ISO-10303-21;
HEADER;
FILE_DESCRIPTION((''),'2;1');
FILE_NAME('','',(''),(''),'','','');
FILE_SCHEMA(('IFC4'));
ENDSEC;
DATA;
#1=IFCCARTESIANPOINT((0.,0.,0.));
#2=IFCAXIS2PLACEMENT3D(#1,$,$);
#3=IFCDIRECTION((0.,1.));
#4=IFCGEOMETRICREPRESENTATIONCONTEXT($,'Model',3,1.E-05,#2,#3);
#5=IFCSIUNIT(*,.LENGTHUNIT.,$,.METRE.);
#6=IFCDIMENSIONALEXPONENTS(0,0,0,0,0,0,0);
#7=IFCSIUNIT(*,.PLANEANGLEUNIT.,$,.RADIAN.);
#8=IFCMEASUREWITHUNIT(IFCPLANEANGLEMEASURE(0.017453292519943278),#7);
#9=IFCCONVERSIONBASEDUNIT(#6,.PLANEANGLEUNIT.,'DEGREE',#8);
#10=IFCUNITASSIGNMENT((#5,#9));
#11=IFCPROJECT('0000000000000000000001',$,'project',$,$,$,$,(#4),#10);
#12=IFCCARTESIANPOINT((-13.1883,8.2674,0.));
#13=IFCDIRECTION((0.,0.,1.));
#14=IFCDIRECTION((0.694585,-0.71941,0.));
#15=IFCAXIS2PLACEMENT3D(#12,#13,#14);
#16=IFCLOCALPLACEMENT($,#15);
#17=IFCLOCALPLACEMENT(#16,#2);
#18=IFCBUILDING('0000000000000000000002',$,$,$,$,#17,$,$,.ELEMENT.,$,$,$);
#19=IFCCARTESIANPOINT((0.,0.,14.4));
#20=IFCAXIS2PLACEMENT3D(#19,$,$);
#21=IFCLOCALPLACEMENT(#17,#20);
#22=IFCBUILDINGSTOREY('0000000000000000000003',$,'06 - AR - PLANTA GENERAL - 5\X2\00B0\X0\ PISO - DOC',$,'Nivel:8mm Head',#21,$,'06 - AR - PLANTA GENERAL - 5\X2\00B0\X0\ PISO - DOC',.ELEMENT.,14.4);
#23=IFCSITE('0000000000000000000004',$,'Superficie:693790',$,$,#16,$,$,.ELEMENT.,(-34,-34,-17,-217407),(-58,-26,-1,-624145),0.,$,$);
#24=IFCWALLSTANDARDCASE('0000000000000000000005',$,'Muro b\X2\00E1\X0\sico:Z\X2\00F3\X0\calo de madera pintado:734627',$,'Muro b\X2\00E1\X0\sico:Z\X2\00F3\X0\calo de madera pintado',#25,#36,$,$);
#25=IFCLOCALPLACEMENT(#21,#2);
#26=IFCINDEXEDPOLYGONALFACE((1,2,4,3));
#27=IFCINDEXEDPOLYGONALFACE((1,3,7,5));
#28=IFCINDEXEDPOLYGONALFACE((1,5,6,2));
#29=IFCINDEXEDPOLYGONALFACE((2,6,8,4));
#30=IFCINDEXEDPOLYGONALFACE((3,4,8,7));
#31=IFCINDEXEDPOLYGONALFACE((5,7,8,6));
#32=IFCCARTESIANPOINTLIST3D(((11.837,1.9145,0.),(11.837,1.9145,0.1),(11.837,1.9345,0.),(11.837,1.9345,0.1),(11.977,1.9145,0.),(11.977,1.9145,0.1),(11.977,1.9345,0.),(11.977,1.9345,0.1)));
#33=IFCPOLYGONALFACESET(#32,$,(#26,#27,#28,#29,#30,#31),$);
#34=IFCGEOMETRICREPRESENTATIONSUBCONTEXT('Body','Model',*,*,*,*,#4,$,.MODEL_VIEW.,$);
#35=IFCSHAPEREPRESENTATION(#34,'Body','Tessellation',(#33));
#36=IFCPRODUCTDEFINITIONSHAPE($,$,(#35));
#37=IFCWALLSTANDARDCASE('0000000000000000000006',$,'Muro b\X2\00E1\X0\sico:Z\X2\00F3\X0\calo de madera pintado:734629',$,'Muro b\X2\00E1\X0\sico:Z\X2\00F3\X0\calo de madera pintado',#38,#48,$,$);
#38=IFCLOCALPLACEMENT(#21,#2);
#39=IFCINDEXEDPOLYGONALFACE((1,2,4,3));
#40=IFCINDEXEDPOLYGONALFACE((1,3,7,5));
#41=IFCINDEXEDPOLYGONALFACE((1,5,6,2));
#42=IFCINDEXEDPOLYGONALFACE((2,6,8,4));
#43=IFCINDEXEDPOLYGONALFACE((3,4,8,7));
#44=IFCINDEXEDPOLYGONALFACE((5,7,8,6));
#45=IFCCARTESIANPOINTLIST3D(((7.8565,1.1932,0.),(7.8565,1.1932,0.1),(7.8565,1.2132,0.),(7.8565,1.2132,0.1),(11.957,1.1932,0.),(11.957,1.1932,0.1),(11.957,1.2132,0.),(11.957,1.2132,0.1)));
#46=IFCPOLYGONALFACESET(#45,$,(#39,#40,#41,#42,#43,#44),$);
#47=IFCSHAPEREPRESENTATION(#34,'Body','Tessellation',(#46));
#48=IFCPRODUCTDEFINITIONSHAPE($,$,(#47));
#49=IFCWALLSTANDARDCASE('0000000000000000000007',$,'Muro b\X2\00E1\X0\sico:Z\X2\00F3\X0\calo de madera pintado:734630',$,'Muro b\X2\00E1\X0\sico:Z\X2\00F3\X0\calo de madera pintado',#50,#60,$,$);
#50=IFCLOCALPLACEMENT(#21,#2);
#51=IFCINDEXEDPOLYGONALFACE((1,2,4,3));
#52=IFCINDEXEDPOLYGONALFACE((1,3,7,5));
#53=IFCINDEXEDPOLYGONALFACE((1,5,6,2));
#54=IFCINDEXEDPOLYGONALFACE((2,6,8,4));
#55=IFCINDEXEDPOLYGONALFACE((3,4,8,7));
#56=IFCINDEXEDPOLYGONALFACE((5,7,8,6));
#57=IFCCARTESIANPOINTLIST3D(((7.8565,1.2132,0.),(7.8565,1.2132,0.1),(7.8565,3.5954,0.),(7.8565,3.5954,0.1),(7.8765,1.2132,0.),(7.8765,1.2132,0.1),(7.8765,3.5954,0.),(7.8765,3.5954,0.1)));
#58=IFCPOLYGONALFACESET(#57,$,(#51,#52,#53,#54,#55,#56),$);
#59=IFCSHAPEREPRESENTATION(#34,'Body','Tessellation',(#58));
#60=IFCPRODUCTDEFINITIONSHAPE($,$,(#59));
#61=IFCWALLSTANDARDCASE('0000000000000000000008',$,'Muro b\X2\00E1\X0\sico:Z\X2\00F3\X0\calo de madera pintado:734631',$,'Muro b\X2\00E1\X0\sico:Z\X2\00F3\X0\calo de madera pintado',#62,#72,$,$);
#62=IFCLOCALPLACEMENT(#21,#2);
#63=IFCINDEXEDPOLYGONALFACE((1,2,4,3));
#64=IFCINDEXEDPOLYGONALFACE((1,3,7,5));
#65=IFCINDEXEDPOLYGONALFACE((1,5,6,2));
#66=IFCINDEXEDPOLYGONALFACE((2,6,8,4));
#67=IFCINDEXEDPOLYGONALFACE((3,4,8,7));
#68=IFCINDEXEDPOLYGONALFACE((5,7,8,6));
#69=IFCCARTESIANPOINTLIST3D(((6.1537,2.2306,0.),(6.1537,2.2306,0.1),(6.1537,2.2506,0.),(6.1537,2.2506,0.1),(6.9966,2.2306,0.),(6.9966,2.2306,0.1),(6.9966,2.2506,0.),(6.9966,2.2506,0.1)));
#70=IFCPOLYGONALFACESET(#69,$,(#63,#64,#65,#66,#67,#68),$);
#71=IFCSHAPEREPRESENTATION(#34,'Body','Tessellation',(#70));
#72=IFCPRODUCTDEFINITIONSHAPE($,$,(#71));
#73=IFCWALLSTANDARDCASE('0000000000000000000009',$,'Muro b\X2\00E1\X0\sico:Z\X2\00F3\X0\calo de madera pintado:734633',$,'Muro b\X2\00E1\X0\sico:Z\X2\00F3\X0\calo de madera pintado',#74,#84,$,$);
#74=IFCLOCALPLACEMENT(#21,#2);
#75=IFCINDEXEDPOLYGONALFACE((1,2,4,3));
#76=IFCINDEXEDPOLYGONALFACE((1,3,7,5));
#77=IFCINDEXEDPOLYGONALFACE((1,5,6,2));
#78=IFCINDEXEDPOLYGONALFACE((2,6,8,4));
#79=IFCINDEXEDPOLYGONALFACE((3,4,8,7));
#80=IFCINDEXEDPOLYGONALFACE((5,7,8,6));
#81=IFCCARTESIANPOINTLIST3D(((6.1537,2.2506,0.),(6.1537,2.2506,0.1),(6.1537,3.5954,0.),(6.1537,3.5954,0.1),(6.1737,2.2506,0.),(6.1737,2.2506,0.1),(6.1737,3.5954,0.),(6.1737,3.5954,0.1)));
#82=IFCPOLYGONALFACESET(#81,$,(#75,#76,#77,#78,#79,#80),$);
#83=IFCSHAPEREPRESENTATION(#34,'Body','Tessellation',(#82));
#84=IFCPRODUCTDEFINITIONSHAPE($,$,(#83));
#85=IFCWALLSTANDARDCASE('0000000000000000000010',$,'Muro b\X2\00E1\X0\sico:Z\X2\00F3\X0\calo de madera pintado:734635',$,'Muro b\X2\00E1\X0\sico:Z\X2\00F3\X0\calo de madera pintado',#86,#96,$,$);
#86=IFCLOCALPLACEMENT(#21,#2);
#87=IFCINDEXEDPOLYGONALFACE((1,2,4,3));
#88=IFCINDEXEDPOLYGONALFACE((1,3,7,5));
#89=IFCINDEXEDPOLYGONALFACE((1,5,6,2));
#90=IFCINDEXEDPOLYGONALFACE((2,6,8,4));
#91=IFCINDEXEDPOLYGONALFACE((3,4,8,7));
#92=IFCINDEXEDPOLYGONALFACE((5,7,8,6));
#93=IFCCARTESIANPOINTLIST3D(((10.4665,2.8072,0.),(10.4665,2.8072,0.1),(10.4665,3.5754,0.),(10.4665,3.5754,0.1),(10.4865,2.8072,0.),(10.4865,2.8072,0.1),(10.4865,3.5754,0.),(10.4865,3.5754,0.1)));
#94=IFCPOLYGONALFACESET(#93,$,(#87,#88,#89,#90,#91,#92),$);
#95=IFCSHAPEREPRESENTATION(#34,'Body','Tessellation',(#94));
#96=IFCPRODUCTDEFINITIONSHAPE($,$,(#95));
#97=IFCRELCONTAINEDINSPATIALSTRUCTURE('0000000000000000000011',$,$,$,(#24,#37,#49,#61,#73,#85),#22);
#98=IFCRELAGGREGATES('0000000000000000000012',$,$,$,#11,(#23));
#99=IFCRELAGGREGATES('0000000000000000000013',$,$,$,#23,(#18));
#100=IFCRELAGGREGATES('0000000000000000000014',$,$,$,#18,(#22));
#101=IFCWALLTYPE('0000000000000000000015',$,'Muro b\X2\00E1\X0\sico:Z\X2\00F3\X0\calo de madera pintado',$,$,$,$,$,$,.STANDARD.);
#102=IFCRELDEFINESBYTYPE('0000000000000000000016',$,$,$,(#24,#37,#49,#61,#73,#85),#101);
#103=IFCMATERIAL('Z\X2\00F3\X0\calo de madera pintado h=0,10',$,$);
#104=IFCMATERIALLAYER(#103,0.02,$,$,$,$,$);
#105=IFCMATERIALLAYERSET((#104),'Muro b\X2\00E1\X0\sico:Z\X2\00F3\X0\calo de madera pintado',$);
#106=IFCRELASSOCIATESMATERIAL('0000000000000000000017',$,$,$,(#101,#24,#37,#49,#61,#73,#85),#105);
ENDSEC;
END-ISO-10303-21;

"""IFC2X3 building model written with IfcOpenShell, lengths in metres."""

from ifc_helpers import new_model, entity, si_unit, converted_unit, direction, frame, frame_2d, origin, place, context, subcontext, project, spatial, rectangle, extrude, material, layer, layer_set, layer_usage, type_object, element, save


model = new_model("IFC2X3")

# Units and contexts
model_context = context("Model", 3, precision=1e-05, world=origin(), true_north=direction((0.0, 1.0)))
body_context = subcontext(model_context, "Body", "Model", "MODEL_VIEW")
ifc_project = project(units=[si_unit("LENGTHUNIT", "METRE"), converted_unit("PLANEANGLEUNIT", "DEGREE", entity("IfcPlaneAngleMeasure", 0.017453292519943278), si_unit("PLANEANGLEUNIT", "RADIAN"), dimensions=[0, 0, 0, 0, 0, 0, 0])], contexts=[model_context])

# Site, building, storey
site_placement = place(None, frame((-13.1883, 8.2674, 0.0), z_axis=(0.0, 0.0, 1.0), x_axis=(0.694585, -0.71941, 0.0)))
site = spatial("IfcSite", under=ifc_project, at=site_placement, Name="Superficie:693790", CompositionType="ELEMENT", RefLatitude=(-34, -34, -17, -217407), RefLongitude=(-58, -26, -1, -624145), RefElevation=0.0)
building_placement = place(site_placement, origin())
building = spatial("IfcBuilding", under=site, at=building_placement, CompositionType="ELEMENT")
storey_placement = place(building_placement, frame((0.0, 0.0, 14.4)))
storey = spatial("IfcBuildingStorey", under=building, at=storey_placement, Name="06 - AR - PLANTA GENERAL - 5° PISO - DOC", ObjectType="Nivel:8mm Head", LongName="06 - AR - PLANTA GENERAL - 5° PISO - DOC", CompositionType="ELEMENT", Elevation=14.4)

# Walls
ifc_material_1 = material(Name="Zócalo de madera pintado h=0,10")
ifc_layer_1 = layer(ifc_material_1, 0.02)
ifc_layer_set_1 = layer_set([ifc_layer_1], Name="Muro básico:Zócalo de madera pintado")
wall_type_1 = type_object("IfcWallType", Name="Muro básico:Zócalo de madera pintado", PredefinedType="STANDARD", material=ifc_layer_set_1)
ifc_layer_usage_1 = layer_usage(ifc_layer_set_1, "AXIS2", "NEGATIVE", 0.01)
wall_1_placement = place(storey_placement, frame((11.977, 1.9245, 0.0), z_axis=(0.0, 0.0, 1.0), x_axis=(-1.0, 0.0, 0.0)))
element("IfcWallStandardCase", 1, at=wall_1_placement, inside=storey, type_object=wall_type_1, material=ifc_layer_usage_1, Name="Muro básico:Zócalo de madera pintado:734627", ObjectType="Muro básico:Zócalo de madera pintado", context=body_context, shape_type="SweptSolid", body=[
    extrude(rectangle(XDim=0.14, YDim=0.02, at=frame_2d((0.07, 0.0), x_axis=(-1.0, 0.0))), origin(), (0.0, 0.0, 1.0), 0.1),
])
ifc_layer_usage_2 = layer_usage(ifc_layer_set_1, "AXIS2", "NEGATIVE", 0.01)
wall_2_placement = place(storey_placement, frame((7.8565, 1.2032, 0.0)))
element("IfcWallStandardCase", 2, at=wall_2_placement, inside=storey, type_object=wall_type_1, material=ifc_layer_usage_2, Name="Muro básico:Zócalo de madera pintado:734629", ObjectType="Muro básico:Zócalo de madera pintado", context=body_context, shape_type="SweptSolid", body=[
    extrude(rectangle(XDim=4.1005, YDim=0.02, at=frame_2d((2.0503, 0.0), x_axis=(-1.0, 0.0))), origin(), (0.0, 0.0, 1.0), 0.1),
])
ifc_layer_usage_3 = layer_usage(ifc_layer_set_1, "AXIS2", "NEGATIVE", 0.01)
wall_3_placement = place(storey_placement, frame((7.8665, 3.5954, 0.0), z_axis=(0.0, 0.0, 1.0), x_axis=(0.0, -1.0, 0.0)))
element("IfcWallStandardCase", 3, at=wall_3_placement, inside=storey, type_object=wall_type_1, material=ifc_layer_usage_3, Name="Muro básico:Zócalo de madera pintado:734630", ObjectType="Muro básico:Zócalo de madera pintado", context=body_context, shape_type="SweptSolid", body=[
    extrude(rectangle(XDim=2.3823, YDim=0.02, at=frame_2d((1.1911, 0.0), x_axis=(-1.0, 0.0))), origin(), (0.0, 0.0, 1.0), 0.1),
])
ifc_layer_usage_4 = layer_usage(ifc_layer_set_1, "AXIS2", "NEGATIVE", 0.01)
wall_4_placement = place(storey_placement, frame((6.9966, 2.2406, 0.0), z_axis=(0.0, 0.0, 1.0), x_axis=(-1.0, 0.0, 0.0)))
element("IfcWallStandardCase", 4, at=wall_4_placement, inside=storey, type_object=wall_type_1, material=ifc_layer_usage_4, Name="Muro básico:Zócalo de madera pintado:734631", ObjectType="Muro básico:Zócalo de madera pintado", context=body_context, shape_type="SweptSolid", body=[
    extrude(rectangle(XDim=0.843, YDim=0.02, at=frame_2d((0.4215, 0.0), x_axis=(-1.0, 0.0))), origin(), (0.0, 0.0, 1.0), 0.1),
])
ifc_layer_usage_5 = layer_usage(ifc_layer_set_1, "AXIS2", "NEGATIVE", 0.01)
wall_5_placement = place(storey_placement, frame((6.1637, 2.2506, 0.0), z_axis=(0.0, 0.0, 1.0), x_axis=(0.0, 1.0, 0.0)))
element("IfcWallStandardCase", 5, at=wall_5_placement, inside=storey, type_object=wall_type_1, material=ifc_layer_usage_5, Name="Muro básico:Zócalo de madera pintado:734633", ObjectType="Muro básico:Zócalo de madera pintado", context=body_context, shape_type="SweptSolid", body=[
    extrude(rectangle(XDim=1.3448, YDim=0.02, at=frame_2d((0.6724, 0.0), x_axis=(-1.0, 0.0))), origin(), (0.0, 0.0, 1.0), 0.1),
])
ifc_layer_usage_6 = layer_usage(ifc_layer_set_1, "AXIS2", "NEGATIVE", 0.01)
wall_6_placement = place(storey_placement, frame((10.4765, 2.8072, 0.0), z_axis=(0.0, 0.0, 1.0), x_axis=(0.0, 1.0, 0.0)))
element("IfcWallStandardCase", 6, at=wall_6_placement, inside=storey, type_object=wall_type_1, material=ifc_layer_usage_6, Name="Muro básico:Zócalo de madera pintado:734635", ObjectType="Muro básico:Zócalo de madera pintado", context=body_context, shape_type="SweptSolid", body=[
    extrude(rectangle(XDim=0.7683, YDim=0.02, at=frame_2d((0.3841, 0.0), x_axis=(-1.0, 0.0))), origin(), (0.0, 0.0, 1.0), 0.1),
])

save(model, "model.ifc")
